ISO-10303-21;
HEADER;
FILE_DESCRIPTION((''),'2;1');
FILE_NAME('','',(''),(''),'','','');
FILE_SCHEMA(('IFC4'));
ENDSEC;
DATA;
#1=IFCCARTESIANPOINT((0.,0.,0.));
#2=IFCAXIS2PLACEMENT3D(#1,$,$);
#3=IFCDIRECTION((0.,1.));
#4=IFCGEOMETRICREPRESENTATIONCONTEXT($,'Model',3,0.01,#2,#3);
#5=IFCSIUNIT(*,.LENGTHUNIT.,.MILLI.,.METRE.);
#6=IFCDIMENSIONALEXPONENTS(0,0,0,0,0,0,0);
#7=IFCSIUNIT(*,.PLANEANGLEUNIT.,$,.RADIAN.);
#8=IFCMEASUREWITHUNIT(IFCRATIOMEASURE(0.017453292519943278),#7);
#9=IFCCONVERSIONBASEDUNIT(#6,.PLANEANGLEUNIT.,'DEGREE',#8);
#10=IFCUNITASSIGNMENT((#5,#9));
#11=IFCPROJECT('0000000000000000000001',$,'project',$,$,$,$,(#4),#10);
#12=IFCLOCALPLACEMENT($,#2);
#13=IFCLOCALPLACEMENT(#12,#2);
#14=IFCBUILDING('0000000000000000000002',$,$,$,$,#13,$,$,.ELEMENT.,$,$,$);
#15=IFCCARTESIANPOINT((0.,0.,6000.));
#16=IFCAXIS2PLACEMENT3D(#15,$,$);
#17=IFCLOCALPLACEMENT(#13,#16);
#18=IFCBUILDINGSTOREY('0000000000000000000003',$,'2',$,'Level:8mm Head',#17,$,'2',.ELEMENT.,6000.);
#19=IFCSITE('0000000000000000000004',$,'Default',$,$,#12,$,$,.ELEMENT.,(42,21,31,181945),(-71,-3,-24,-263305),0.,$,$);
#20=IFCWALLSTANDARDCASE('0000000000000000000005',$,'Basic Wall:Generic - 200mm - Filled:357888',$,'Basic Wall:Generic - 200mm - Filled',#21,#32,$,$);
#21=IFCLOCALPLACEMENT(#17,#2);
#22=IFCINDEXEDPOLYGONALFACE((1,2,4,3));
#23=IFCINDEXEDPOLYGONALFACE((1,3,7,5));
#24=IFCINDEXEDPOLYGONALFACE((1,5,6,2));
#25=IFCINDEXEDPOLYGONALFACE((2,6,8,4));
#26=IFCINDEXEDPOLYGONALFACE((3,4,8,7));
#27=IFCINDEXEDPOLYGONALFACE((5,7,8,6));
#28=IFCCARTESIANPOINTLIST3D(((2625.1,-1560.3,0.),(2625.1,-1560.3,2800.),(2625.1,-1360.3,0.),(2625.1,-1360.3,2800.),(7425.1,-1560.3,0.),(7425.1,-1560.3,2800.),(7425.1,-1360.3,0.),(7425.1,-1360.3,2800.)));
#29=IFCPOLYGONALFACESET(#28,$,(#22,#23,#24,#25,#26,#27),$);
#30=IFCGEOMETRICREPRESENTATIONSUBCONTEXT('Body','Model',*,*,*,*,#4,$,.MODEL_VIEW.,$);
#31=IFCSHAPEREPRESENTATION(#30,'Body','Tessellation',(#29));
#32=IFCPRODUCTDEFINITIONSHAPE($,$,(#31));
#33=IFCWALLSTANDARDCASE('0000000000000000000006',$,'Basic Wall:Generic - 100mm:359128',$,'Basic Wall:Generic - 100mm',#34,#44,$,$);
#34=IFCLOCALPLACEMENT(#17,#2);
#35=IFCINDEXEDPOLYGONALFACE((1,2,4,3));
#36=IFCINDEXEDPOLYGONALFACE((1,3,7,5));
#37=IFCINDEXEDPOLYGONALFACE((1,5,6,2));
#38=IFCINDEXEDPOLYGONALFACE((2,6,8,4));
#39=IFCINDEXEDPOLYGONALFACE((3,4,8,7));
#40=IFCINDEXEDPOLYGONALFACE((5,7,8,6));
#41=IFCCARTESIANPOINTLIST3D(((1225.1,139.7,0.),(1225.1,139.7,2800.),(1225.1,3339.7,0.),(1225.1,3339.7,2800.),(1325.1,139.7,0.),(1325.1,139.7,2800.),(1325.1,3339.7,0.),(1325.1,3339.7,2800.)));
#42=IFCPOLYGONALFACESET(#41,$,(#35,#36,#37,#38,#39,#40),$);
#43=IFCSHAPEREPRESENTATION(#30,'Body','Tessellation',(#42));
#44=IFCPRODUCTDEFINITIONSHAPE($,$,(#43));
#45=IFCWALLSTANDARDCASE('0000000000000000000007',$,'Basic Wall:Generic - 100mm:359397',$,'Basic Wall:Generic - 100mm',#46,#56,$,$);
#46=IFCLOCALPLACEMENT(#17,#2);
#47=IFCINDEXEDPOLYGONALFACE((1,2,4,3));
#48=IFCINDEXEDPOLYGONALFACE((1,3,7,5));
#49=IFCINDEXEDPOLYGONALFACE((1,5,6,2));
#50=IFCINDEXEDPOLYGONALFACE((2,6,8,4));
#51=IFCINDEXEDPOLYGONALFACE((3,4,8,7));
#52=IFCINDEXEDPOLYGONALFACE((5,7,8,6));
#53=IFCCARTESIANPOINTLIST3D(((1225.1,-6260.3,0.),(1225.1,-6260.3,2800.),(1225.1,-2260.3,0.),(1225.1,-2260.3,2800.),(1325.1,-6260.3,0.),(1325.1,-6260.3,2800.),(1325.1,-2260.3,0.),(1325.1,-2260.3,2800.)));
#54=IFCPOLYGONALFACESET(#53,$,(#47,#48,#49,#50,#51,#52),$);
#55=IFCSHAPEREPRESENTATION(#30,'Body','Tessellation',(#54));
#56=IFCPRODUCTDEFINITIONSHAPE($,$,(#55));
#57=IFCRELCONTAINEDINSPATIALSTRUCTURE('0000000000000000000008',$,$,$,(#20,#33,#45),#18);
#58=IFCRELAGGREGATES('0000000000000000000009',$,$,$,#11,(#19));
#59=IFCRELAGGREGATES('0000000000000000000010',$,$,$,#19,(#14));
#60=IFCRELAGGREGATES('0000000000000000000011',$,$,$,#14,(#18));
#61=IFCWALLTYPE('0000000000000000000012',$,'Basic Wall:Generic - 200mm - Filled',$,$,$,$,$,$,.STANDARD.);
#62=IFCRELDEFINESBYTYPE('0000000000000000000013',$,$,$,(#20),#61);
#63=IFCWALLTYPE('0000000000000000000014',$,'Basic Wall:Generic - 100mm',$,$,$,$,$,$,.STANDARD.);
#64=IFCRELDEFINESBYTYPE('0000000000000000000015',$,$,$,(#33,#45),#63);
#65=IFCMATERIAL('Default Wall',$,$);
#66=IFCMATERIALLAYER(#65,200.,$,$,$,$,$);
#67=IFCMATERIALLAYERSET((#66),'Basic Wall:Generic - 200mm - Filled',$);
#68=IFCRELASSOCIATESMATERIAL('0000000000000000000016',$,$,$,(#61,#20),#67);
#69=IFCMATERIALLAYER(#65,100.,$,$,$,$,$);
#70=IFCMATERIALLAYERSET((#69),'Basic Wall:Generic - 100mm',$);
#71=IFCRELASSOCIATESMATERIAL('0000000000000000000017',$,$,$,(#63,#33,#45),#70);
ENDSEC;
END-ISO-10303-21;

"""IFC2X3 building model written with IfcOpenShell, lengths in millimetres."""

from ifc_helpers import new_model, entity, si_unit, converted_unit, direction, frame, frame_2d, origin, place, context, subcontext, project, spatial, rectangle, extrude, material, layer, layer_set, layer_usage, type_object, element, save


model = new_model("IFC2X3")

# Units and contexts
model_context = context("Model", 3, precision=0.01, world=origin(), true_north=direction((0.0, 1.0)))
body_context = subcontext(model_context, "Body", "Model", "MODEL_VIEW")
ifc_project = project(units=[si_unit("LENGTHUNIT", "METRE", prefix="MILLI"), converted_unit("PLANEANGLEUNIT", "DEGREE", entity("IfcRatioMeasure", 0.017453292519943278), si_unit("PLANEANGLEUNIT", "RADIAN"), dimensions=[0, 0, 0, 0, 0, 0, 0])], contexts=[model_context])

# Site, building, storey
site_placement = place(None, origin())
site = spatial("IfcSite", under=ifc_project, at=site_placement, Name="Default", CompositionType="ELEMENT", RefLatitude=(42, 21, 31, 181945), RefLongitude=(-71, -3, -24, -263305), RefElevation=0.0)
building_placement = place(site_placement, origin())
building = spatial("IfcBuilding", under=site, at=building_placement, CompositionType="ELEMENT")
storey_placement = place(building_placement, frame((0.0, 0.0, 6000.0)))
storey = spatial("IfcBuildingStorey", under=building, at=storey_placement, Name="2", ObjectType="Level:8mm Head", LongName="2", CompositionType="ELEMENT", Elevation=6000.0)

# Shared definitions
ifc_material_1 = material(Name="Default Wall")
ifc_layer_1 = layer(ifc_material_1, 200.0)
ifc_layer_set_1 = layer_set([ifc_layer_1], Name="Basic Wall:Generic - 200mm - Filled")
ifc_layer_usage_1 = layer_usage(ifc_layer_set_1, "AXIS2", "NEGATIVE", 100.0)
wall_type_1 = type_object("IfcWallType", Name="Basic Wall:Generic - 200mm - Filled", PredefinedType="STANDARD", material=ifc_layer_set_1)

# Walls
wall_1_placement = place(storey_placement, frame((2625.1, -1460.3, 0.0)))
element("IfcWallStandardCase", 1, at=wall_1_placement, inside=storey, type_object=wall_type_1, material=ifc_layer_usage_1, Name="Basic Wall:Generic - 200mm - Filled:357888", ObjectType="Basic Wall:Generic - 200mm - Filled", context=body_context, shape_type="SweptSolid", body=[
    extrude(rectangle(XDim=4800.0, YDim=200.0, at=frame_2d((2400.0, 0.0), x_axis=(-1.0, 0.0))), origin(), (0.0, 0.0, 1.0), 2800.0),
])
ifc_layer_2 = layer(ifc_material_1, 100.0)
ifc_layer_set_2 = layer_set([ifc_layer_2], Name="Basic Wall:Generic - 100mm")
ifc_layer_usage_2 = layer_usage(ifc_layer_set_2, "AXIS2", "NEGATIVE", 50.0)
wall_type_2 = type_object("IfcWallType", Name="Basic Wall:Generic - 100mm", PredefinedType="STANDARD", material=ifc_layer_set_2)
wall_2_placement = place(storey_placement, frame((1275.1, 139.7, 0.0), z_axis=(0.0, 0.0, 1.0), x_axis=(0.0, 1.0, 0.0)))
element("IfcWallStandardCase", 2, at=wall_2_placement, inside=storey, type_object=wall_type_2, material=ifc_layer_usage_2, Name="Basic Wall:Generic - 100mm:359128", ObjectType="Basic Wall:Generic - 100mm", context=body_context, shape_type="SweptSolid", body=[
    extrude(rectangle(XDim=3200.0, YDim=100.0, at=frame_2d((1600.0, 0.0), x_axis=(-1.0, 0.0))), origin(), (0.0, 0.0, 1.0), 2800.0),
])
wall_3_placement = place(storey_placement, frame((1275.1, -2260.3, 0.0), z_axis=(0.0, 0.0, 1.0), x_axis=(0.0, -1.0, 0.0)))
element("IfcWallStandardCase", 3, at=wall_3_placement, inside=storey, type_object=wall_type_2, material=ifc_layer_usage_2, Name="Basic Wall:Generic - 100mm:359397", ObjectType="Basic Wall:Generic - 100mm", context=body_context, shape_type="SweptSolid", body=[
    extrude(rectangle(XDim=4000.0, YDim=100.0, at=frame_2d((2000.0, 0.0), x_axis=(-1.0, 0.0))), origin(), (0.0, 0.0, 1.0), 2800.0),
])

save(model, "model.ifc")
